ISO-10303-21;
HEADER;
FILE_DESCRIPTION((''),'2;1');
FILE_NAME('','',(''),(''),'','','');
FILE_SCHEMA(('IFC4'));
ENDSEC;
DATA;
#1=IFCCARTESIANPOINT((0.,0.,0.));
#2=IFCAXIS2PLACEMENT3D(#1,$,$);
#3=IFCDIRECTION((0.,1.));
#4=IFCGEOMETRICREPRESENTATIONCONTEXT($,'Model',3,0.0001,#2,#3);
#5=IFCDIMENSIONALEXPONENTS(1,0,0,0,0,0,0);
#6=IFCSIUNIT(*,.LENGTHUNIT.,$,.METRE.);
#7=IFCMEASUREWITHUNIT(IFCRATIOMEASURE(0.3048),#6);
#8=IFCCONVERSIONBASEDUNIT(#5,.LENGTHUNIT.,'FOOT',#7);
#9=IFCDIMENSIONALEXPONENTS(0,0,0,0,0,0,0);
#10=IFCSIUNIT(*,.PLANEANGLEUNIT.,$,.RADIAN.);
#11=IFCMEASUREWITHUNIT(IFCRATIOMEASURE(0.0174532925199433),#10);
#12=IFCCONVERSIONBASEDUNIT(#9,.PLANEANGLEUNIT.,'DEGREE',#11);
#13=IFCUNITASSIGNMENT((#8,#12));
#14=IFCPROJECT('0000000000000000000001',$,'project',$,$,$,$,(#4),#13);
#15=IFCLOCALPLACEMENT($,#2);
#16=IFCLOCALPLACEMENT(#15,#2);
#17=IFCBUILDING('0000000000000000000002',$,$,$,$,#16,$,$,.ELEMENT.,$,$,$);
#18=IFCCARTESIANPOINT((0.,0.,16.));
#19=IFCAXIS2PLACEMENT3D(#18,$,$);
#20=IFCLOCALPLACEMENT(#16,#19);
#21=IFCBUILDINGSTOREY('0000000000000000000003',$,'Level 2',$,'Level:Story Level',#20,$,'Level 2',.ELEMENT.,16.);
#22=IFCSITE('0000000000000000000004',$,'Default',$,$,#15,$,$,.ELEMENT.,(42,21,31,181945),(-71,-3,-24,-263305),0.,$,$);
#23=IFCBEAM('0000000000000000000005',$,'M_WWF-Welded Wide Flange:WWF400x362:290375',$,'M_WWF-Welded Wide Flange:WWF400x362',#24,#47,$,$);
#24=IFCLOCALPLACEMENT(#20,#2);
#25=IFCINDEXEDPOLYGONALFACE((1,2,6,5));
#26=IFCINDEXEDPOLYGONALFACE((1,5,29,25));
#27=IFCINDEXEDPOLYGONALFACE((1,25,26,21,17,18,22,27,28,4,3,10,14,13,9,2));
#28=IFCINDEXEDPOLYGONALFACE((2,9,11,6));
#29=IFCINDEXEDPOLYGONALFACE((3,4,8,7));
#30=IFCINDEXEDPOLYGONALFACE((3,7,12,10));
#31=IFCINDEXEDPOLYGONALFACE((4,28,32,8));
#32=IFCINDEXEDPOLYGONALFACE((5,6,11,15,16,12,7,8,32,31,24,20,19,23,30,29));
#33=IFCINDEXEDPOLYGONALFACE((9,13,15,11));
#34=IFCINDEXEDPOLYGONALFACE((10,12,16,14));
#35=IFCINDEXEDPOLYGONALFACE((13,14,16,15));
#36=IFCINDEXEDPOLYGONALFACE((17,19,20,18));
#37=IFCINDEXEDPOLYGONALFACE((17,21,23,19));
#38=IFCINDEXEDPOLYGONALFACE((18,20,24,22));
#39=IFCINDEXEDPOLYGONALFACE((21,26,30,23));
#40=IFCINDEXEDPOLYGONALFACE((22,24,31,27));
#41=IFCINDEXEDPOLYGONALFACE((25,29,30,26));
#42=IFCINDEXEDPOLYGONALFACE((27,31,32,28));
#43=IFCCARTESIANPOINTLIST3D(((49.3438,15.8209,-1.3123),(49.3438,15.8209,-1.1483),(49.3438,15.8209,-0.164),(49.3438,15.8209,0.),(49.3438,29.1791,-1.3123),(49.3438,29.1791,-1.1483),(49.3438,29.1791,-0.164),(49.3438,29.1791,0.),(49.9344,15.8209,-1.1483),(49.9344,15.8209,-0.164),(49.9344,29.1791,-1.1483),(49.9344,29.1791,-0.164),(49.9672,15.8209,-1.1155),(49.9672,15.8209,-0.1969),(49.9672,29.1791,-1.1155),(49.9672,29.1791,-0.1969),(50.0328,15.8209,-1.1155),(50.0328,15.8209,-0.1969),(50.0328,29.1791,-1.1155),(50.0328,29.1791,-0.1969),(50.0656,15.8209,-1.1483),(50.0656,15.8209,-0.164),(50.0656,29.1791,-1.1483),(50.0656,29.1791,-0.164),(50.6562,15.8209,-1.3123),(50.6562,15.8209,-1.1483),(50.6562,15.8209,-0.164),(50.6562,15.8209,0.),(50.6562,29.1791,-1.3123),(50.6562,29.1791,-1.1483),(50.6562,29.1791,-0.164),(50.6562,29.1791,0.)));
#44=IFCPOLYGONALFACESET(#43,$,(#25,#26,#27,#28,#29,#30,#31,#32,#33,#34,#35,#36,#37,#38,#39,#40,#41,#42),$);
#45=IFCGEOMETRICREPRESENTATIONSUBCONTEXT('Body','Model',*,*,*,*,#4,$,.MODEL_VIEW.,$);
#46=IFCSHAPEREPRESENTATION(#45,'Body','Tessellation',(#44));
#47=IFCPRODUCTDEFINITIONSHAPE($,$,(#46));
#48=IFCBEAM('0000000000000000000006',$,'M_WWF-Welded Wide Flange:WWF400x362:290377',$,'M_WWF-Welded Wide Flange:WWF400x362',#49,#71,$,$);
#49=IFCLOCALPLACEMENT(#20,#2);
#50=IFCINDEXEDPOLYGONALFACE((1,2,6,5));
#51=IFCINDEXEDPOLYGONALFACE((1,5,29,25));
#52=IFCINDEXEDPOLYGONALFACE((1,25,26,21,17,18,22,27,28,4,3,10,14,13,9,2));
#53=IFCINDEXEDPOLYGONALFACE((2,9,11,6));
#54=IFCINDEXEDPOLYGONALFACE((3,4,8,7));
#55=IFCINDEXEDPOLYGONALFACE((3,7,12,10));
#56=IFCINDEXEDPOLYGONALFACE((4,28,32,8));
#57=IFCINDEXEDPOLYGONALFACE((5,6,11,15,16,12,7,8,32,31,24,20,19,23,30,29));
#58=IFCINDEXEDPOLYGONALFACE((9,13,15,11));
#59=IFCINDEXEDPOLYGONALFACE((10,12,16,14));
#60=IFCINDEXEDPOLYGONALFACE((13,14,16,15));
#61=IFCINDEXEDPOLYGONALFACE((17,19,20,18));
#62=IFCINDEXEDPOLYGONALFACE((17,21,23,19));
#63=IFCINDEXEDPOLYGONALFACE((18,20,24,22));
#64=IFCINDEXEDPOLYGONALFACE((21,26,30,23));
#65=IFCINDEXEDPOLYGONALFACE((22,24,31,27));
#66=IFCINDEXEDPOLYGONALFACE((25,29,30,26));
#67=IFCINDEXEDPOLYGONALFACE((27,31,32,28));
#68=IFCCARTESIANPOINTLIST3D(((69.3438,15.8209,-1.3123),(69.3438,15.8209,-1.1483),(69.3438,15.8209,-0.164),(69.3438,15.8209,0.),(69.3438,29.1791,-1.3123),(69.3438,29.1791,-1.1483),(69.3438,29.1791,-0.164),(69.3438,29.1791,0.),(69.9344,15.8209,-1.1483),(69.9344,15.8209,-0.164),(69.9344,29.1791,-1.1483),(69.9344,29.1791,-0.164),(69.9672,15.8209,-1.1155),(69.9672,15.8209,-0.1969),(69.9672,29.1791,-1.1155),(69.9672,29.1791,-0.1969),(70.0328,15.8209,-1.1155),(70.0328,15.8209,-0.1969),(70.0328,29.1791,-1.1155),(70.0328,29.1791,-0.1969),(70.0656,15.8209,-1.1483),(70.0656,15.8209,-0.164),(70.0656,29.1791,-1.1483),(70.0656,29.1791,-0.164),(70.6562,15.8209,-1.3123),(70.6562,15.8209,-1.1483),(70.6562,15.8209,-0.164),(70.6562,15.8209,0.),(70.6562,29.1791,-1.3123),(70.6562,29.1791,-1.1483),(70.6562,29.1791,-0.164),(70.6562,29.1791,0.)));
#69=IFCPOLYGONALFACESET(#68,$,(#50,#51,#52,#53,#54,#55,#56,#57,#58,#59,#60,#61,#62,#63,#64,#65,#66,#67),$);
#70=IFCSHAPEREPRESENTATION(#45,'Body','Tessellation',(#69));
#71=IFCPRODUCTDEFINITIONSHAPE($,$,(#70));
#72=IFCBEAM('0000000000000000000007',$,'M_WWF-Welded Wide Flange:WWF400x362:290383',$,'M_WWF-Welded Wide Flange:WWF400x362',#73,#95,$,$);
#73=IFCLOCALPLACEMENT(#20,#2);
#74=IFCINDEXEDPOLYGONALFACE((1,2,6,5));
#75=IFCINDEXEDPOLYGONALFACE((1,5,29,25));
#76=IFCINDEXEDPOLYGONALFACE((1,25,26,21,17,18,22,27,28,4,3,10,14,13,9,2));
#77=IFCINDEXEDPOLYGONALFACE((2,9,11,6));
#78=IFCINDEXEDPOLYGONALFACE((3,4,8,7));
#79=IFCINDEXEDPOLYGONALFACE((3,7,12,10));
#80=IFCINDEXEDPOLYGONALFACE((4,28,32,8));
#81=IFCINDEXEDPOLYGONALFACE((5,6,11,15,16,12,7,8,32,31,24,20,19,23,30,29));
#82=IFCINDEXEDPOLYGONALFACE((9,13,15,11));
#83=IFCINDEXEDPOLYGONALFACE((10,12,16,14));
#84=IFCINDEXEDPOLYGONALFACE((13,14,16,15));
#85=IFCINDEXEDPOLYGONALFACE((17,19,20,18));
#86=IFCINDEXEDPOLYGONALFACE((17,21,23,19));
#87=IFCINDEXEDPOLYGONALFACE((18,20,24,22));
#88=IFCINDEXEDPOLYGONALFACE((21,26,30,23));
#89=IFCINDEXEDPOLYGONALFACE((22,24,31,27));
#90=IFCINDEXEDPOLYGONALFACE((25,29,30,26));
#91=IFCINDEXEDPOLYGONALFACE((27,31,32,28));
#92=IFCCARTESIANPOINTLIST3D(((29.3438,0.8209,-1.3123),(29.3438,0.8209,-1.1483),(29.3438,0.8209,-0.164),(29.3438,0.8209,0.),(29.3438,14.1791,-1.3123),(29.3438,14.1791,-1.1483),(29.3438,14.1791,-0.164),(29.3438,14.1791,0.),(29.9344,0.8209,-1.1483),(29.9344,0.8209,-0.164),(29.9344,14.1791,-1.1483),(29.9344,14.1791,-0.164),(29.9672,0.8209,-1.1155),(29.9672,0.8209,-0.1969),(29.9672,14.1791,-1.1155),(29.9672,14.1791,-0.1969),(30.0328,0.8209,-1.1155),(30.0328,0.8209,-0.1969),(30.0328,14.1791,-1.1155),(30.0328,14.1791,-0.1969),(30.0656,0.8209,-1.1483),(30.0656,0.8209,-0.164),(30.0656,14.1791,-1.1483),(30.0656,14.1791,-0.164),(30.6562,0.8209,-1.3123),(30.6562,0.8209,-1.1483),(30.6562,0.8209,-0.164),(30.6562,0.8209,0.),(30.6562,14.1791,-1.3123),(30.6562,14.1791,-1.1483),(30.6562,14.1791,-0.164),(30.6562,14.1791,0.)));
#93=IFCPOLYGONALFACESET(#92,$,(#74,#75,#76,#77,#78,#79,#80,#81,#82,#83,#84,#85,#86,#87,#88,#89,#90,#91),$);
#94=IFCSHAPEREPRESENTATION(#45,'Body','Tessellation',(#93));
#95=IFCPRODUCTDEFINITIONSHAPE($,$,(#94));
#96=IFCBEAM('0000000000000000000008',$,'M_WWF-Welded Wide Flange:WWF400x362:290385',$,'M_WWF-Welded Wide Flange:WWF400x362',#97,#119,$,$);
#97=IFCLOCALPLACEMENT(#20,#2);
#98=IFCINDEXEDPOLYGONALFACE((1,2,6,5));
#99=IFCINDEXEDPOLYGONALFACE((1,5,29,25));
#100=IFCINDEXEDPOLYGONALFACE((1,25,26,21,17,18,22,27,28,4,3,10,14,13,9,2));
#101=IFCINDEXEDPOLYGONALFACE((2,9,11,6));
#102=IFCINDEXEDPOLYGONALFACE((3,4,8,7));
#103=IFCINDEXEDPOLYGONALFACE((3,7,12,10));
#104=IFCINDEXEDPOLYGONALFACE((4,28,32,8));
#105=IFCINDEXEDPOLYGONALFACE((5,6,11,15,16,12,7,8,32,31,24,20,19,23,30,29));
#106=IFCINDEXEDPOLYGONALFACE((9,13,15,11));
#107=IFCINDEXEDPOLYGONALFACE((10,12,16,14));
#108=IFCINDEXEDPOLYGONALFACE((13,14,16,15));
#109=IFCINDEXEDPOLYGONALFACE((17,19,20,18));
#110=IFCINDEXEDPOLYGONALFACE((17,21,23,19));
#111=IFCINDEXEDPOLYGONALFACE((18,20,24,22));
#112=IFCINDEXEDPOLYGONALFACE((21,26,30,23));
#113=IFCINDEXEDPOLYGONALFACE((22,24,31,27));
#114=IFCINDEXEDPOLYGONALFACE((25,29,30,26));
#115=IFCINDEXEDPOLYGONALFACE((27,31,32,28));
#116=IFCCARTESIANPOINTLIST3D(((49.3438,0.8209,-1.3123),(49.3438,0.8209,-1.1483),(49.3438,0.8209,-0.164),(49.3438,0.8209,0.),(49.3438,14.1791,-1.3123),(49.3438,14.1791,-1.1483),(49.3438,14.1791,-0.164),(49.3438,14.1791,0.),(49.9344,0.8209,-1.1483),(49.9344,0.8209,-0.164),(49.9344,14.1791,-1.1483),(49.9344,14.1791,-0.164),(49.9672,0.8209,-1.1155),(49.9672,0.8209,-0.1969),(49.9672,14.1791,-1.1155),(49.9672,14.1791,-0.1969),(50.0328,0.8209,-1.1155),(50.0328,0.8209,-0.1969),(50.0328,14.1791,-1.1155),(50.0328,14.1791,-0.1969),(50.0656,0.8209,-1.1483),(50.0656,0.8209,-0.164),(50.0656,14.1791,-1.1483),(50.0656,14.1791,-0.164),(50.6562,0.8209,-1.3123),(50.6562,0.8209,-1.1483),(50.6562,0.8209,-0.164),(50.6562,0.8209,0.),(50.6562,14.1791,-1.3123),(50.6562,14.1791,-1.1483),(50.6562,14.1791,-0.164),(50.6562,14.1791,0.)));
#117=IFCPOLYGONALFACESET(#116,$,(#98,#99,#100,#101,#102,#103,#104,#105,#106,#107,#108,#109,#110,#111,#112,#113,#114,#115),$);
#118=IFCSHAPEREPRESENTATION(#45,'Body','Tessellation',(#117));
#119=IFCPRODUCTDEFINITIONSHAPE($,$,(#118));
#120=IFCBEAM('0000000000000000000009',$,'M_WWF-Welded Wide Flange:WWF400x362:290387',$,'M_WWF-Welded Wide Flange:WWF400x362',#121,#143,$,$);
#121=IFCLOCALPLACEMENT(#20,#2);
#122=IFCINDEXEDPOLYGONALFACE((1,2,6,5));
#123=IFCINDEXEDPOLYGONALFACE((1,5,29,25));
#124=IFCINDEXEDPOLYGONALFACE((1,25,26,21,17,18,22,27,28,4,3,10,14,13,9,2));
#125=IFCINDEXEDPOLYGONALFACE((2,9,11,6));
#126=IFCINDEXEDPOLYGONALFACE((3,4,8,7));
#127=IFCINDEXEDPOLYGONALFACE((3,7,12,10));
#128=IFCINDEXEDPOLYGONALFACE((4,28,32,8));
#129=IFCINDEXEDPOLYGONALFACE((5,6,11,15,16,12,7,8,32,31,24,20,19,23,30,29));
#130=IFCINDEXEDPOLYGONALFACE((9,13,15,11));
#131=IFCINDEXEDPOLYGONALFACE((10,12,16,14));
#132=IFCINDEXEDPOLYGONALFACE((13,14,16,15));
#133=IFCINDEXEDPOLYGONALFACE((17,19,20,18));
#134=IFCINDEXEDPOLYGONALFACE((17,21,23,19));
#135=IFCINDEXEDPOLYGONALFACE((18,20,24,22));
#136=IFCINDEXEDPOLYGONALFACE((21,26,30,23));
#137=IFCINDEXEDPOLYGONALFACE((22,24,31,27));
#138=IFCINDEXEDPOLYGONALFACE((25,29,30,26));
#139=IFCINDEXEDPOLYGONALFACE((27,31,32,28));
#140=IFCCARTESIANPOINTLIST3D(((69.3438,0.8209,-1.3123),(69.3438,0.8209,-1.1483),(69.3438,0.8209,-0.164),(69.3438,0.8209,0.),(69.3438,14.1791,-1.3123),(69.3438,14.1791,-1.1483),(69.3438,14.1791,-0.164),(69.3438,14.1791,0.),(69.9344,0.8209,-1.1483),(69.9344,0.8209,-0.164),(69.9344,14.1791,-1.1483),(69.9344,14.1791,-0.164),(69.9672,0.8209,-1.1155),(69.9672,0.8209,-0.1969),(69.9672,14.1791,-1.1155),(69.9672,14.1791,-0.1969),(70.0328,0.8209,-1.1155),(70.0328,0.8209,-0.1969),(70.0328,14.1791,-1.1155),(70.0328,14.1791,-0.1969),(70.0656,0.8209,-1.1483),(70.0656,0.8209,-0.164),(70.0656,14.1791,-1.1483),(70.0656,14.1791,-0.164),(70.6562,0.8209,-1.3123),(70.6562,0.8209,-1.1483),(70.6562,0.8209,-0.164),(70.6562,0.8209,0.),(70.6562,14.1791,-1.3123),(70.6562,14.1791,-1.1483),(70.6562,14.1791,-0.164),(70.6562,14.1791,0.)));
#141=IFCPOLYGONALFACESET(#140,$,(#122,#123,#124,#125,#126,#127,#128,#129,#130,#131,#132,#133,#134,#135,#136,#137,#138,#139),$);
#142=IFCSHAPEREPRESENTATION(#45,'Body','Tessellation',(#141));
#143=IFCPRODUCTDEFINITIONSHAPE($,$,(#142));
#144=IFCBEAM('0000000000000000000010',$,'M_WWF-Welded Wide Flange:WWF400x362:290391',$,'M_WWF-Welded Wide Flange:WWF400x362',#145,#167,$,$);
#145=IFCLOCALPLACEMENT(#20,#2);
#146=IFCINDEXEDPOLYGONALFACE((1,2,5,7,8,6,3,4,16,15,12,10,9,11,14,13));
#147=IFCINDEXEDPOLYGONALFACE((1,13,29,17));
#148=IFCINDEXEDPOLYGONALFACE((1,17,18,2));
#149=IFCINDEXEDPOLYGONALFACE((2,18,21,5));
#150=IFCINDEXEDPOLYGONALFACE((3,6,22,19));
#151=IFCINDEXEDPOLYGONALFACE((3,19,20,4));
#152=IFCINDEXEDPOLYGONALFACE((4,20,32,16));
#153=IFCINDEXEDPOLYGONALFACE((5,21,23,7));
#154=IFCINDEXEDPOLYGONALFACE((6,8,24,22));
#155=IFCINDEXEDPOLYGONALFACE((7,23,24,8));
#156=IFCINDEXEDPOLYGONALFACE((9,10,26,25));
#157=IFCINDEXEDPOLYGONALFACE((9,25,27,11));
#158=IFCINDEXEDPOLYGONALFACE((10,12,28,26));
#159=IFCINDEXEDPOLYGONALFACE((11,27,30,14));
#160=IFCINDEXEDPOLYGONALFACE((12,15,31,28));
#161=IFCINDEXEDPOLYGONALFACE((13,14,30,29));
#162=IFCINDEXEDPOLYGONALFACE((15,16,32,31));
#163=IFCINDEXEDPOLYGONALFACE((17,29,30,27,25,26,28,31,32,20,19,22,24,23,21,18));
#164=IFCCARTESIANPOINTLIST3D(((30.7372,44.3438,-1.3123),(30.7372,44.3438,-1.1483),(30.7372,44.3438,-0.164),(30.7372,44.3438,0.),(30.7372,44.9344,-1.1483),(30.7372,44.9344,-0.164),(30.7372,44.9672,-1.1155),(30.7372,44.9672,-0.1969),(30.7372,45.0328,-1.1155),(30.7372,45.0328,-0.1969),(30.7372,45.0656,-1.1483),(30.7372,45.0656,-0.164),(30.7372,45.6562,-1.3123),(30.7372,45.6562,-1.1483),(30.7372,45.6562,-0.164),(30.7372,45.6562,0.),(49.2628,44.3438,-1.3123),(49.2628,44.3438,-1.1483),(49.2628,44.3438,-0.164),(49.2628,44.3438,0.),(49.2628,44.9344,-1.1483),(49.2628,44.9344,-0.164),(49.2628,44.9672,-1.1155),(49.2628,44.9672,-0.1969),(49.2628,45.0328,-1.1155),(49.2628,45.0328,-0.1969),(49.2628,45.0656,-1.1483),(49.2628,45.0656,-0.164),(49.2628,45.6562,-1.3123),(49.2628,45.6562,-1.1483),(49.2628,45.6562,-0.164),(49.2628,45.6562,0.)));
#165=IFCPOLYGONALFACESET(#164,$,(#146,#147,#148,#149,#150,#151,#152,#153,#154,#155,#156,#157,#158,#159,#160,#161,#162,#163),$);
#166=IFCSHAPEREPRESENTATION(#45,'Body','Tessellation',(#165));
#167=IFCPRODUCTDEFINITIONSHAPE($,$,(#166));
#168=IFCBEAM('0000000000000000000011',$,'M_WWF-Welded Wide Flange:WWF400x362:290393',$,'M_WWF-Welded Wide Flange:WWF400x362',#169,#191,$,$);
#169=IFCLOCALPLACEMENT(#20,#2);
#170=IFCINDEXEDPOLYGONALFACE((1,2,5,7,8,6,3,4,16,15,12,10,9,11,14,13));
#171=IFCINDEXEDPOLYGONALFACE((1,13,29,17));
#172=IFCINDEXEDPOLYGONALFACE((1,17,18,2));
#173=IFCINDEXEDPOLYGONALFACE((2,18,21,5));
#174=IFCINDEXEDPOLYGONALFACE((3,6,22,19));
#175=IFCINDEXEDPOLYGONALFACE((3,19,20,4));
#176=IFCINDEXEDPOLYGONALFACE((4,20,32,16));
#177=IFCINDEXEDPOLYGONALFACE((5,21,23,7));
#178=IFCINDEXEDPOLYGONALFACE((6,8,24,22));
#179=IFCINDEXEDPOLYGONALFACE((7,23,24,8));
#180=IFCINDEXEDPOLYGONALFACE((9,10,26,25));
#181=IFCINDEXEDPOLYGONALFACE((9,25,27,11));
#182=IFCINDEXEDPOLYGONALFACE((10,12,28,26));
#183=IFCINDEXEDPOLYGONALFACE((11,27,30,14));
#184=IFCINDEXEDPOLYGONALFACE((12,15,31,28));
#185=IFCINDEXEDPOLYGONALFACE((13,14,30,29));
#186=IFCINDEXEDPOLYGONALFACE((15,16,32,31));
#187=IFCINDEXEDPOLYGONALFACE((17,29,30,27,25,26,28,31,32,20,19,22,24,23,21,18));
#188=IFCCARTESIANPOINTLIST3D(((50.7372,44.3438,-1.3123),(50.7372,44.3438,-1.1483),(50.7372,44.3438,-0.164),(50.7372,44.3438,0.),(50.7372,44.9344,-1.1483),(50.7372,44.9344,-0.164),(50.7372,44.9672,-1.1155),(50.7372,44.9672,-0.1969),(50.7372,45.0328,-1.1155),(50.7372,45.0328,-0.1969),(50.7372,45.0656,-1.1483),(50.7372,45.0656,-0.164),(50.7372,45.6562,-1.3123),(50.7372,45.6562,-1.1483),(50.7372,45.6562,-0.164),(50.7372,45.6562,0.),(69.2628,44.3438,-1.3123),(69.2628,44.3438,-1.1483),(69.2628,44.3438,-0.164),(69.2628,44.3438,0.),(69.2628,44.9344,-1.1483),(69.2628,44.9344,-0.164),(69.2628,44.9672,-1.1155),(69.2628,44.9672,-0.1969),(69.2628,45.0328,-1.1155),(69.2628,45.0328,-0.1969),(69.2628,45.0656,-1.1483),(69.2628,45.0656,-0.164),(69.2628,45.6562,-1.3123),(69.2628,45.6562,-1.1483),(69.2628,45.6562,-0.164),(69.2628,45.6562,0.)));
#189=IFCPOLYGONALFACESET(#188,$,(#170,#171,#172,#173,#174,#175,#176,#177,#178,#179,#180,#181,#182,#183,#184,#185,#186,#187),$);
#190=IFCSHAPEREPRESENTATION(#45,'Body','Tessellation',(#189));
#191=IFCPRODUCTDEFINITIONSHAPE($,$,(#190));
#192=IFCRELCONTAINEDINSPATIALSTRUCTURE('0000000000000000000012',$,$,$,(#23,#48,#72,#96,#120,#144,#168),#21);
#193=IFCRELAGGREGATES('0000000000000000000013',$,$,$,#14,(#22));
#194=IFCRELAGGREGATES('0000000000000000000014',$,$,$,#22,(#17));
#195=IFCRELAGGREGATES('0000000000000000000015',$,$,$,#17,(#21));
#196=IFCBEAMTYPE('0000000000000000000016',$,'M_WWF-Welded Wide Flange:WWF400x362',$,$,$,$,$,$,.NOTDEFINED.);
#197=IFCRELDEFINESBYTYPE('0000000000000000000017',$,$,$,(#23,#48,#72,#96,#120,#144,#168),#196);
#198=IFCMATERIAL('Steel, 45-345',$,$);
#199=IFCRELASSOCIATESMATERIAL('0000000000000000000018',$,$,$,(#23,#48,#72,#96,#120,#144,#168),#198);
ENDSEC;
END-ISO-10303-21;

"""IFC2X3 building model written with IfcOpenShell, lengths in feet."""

from ifc_helpers import new_model, entity, si_unit, converted_unit, direction, frame, origin, place, context, subcontext, project, spatial, polyline, outline, extrude, material, type_object, element, save


model = new_model("IFC2X3")

# Units and contexts
model_context = context("Model", 3, precision=0.0001, world=origin(), true_north=direction((0.0, 1.0)))
body_context = subcontext(model_context, "Body", "Model", "MODEL_VIEW")
ifc_project = project(units=[converted_unit("LENGTHUNIT", "FOOT", entity("IfcRatioMeasure", 0.3048), si_unit("LENGTHUNIT", "METRE"), dimensions=[1, 0, 0, 0, 0, 0, 0]), converted_unit("PLANEANGLEUNIT", "DEGREE", entity("IfcRatioMeasure", 0.0174532925199433), si_unit("PLANEANGLEUNIT", "RADIAN"), dimensions=[0, 0, 0, 0, 0, 0, 0])], contexts=[model_context])

# Site, building, storey
site_placement = place(None, origin())
site = spatial("IfcSite", under=ifc_project, at=site_placement, Name="Default", CompositionType="ELEMENT", RefLatitude=(42, 21, 31, 181945), RefLongitude=(-71, -3, -24, -263305), RefElevation=0.0)
building_placement = place(site_placement, origin())
building = spatial("IfcBuilding", under=site, at=building_placement, CompositionType="ELEMENT")
storey_placement = place(building_placement, frame((0.0, 0.0, 16.0)))
storey = spatial("IfcBuildingStorey", under=building, at=storey_placement, Name="Level 2", ObjectType="Level:Story Level", LongName="Level 2", CompositionType="ELEMENT", Elevation=16.0)

# Shared definitions
ifc_material = material(Name="Steel, 45-345")

# Beams
beam_type = type_object("IfcBeamType", Name="M_WWF-Welded Wide Flange:WWF400x362", PredefinedType="NOTDEFINED")
for number, where, z_axis, x_axis, name in (
    (1, (50.0, 15.0, 0.0), (0.0, 0.0, 1.0), (0.0, 1.0, 0.0), "M_WWF-Welded Wide Flange:WWF400x362:290375"),
    (2, (70.0, 15.0, 0.0), (0.0, 0.0, 1.0), (0.0, 1.0, 0.0), "M_WWF-Welded Wide Flange:WWF400x362:290377"),
):
    element("IfcBeam", number, at=place(storey_placement, frame(where, z_axis=z_axis, x_axis=x_axis)), inside=storey, type_object=beam_type, material=ifc_material, Name=name, ObjectType="M_WWF-Welded Wide Flange:WWF400x362", context=body_context, shape_type="SweptSolid", body=[
        extrude(outline(polyline([(-0.6562, -0.6562), (-0.4921, -0.6562), (-0.4921, -0.0656), (-0.4593, -0.0328), (0.4593, -0.0328), (0.4921, -0.0656), (0.4921, -0.6562), (0.6562, -0.6562), (0.6562, 0.6562), (0.4921, 0.6562), (0.4921, 0.0656), (0.4593, 0.0328), (-0.4593, 0.0328), (-0.4921, 0.0656), (-0.4921, 0.6562), (-0.6562, 0.6562), (-0.6562, -0.6562)])), frame((0.8209, 0.0, -0.6562), z_axis=(1.0, 0.0, 0.0), x_axis=(0.0, 0.0, -1.0)), (0.0, 0.0, 1.0), 13.3583),
    ])
beam_1_placement = place(storey_placement, frame((30.0, 0.0, 0.0), z_axis=(0.0, 0.0, 1.0), x_axis=(0.0, 1.0, 0.0)))
element("IfcBeam", 3, at=beam_1_placement, inside=storey, type_object=beam_type, material=ifc_material, Name="M_WWF-Welded Wide Flange:WWF400x362:290383", ObjectType="M_WWF-Welded Wide Flange:WWF400x362", context=body_context, shape_type="SweptSolid", body=[
    extrude(outline(polyline([(-0.6562, -0.6562), (-0.4921, -0.6562), (-0.4921, -0.0656), (-0.4593, -0.0328), (0.4593, -0.0328), (0.4921, -0.0656), (0.4921, -0.6562), (0.6562, -0.6562), (0.6562, 0.6562), (0.4921, 0.6562), (0.4921, 0.0656), (0.4593, 0.0328), (-0.4593, 0.0328), (-0.4921, 0.0656), (-0.4921, 0.6562), (-0.6562, 0.6562), (-0.6562, -0.6562)])), frame((0.8209, 0.0, -0.6562), z_axis=(1.0, 0.0, 0.0), x_axis=(0.0, 0.0, -1.0)), (0.0, 0.0, 1.0), 13.3583),
])
beam_2_placement = place(storey_placement, frame((50.0, 0.0, 0.0), z_axis=(0.0, 0.0, 1.0), x_axis=(0.0, 1.0, 0.0)))
element("IfcBeam", 4, at=beam_2_placement, inside=storey, type_object=beam_type, material=ifc_material, Name="M_WWF-Welded Wide Flange:WWF400x362:290385", ObjectType="M_WWF-Welded Wide Flange:WWF400x362", context=body_context, shape_type="SweptSolid", body=[
    extrude(outline(polyline([(-0.6562, -0.6562), (-0.4921, -0.6562), (-0.4921, -0.0656), (-0.4593, -0.0328), (0.4593, -0.0328), (0.4921, -0.0656), (0.4921, -0.6562), (0.6562, -0.6562), (0.6562, 0.6562), (0.4921, 0.6562), (0.4921, 0.0656), (0.4593, 0.0328), (-0.4593, 0.0328), (-0.4921, 0.0656), (-0.4921, 0.6562), (-0.6562, 0.6562), (-0.6562, -0.6562)])), frame((0.8209, 0.0, -0.6562), z_axis=(1.0, 0.0, 0.0), x_axis=(0.0, 0.0, -1.0)), (0.0, 0.0, 1.0), 13.3583),
])
beam_3_placement = place(storey_placement, frame((70.0, 0.0, 0.0), z_axis=(0.0, 0.0, 1.0), x_axis=(0.0, 1.0, 0.0)))
element("IfcBeam", 5, at=beam_3_placement, inside=storey, type_object=beam_type, material=ifc_material, Name="M_WWF-Welded Wide Flange:WWF400x362:290387", ObjectType="M_WWF-Welded Wide Flange:WWF400x362", context=body_context, shape_type="SweptSolid", body=[
    extrude(outline(polyline([(-0.6562, -0.6562), (-0.4921, -0.6562), (-0.4921, -0.0656), (-0.4593, -0.0328), (0.4593, -0.0328), (0.4921, -0.0656), (0.4921, -0.6562), (0.6562, -0.6562), (0.6562, 0.6562), (0.4921, 0.6562), (0.4921, 0.0656), (0.4593, 0.0328), (-0.4593, 0.0328), (-0.4921, 0.0656), (-0.4921, 0.6562), (-0.6562, 0.6562), (-0.6562, -0.6562)])), frame((0.8209, 0.0, -0.6562), z_axis=(1.0, 0.0, 0.0), x_axis=(0.0, 0.0, -1.0)), (0.0, 0.0, 1.0), 13.3583),
])
beam_4_placement = place(storey_placement, frame((30.0, 45.0, 0.0)))
element("IfcBeam", 6, at=beam_4_placement, inside=storey, type_object=beam_type, material=ifc_material, Name="M_WWF-Welded Wide Flange:WWF400x362:290391", ObjectType="M_WWF-Welded Wide Flange:WWF400x362", context=body_context, shape_type="SweptSolid", body=[
    extrude(outline(polyline([(-0.6562, -0.6562), (-0.4921, -0.6562), (-0.4921, -0.0656), (-0.4593, -0.0328), (0.4593, -0.0328), (0.4921, -0.0656), (0.4921, -0.6562), (0.6562, -0.6562), (0.6562, 0.6562), (0.4921, 0.6562), (0.4921, 0.0656), (0.4593, 0.0328), (-0.4593, 0.0328), (-0.4921, 0.0656), (-0.4921, 0.6562), (-0.6562, 0.6562), (-0.6562, -0.6562)])), frame((0.7372, 0.0, -0.6562), z_axis=(1.0, 0.0, 0.0), x_axis=(0.0, 0.0, -1.0)), (0.0, 0.0, 1.0), 18.5256),
])
beam_5_placement = place(storey_placement, frame((50.0, 45.0, 0.0)))
element("IfcBeam", 7, at=beam_5_placement, inside=storey, type_object=beam_type, material=ifc_material, Name="M_WWF-Welded Wide Flange:WWF400x362:290393", ObjectType="M_WWF-Welded Wide Flange:WWF400x362", context=body_context, shape_type="SweptSolid", body=[
    extrude(outline(polyline([(-0.6562, -0.6562), (-0.4921, -0.6562), (-0.4921, -0.0656), (-0.4593, -0.0328), (0.4593, -0.0328), (0.4921, -0.0656), (0.4921, -0.6562), (0.6562, -0.6562), (0.6562, 0.6562), (0.4921, 0.6562), (0.4921, 0.0656), (0.4593, 0.0328), (-0.4593, 0.0328), (-0.4921, 0.0656), (-0.4921, 0.6562), (-0.6562, 0.6562), (-0.6562, -0.6562)])), frame((0.7372, 0.0, -0.6562), z_axis=(1.0, 0.0, 0.0), x_axis=(0.0, 0.0, -1.0)), (0.0, 0.0, 1.0), 18.5256),
])

save(model, "model.ifc")
